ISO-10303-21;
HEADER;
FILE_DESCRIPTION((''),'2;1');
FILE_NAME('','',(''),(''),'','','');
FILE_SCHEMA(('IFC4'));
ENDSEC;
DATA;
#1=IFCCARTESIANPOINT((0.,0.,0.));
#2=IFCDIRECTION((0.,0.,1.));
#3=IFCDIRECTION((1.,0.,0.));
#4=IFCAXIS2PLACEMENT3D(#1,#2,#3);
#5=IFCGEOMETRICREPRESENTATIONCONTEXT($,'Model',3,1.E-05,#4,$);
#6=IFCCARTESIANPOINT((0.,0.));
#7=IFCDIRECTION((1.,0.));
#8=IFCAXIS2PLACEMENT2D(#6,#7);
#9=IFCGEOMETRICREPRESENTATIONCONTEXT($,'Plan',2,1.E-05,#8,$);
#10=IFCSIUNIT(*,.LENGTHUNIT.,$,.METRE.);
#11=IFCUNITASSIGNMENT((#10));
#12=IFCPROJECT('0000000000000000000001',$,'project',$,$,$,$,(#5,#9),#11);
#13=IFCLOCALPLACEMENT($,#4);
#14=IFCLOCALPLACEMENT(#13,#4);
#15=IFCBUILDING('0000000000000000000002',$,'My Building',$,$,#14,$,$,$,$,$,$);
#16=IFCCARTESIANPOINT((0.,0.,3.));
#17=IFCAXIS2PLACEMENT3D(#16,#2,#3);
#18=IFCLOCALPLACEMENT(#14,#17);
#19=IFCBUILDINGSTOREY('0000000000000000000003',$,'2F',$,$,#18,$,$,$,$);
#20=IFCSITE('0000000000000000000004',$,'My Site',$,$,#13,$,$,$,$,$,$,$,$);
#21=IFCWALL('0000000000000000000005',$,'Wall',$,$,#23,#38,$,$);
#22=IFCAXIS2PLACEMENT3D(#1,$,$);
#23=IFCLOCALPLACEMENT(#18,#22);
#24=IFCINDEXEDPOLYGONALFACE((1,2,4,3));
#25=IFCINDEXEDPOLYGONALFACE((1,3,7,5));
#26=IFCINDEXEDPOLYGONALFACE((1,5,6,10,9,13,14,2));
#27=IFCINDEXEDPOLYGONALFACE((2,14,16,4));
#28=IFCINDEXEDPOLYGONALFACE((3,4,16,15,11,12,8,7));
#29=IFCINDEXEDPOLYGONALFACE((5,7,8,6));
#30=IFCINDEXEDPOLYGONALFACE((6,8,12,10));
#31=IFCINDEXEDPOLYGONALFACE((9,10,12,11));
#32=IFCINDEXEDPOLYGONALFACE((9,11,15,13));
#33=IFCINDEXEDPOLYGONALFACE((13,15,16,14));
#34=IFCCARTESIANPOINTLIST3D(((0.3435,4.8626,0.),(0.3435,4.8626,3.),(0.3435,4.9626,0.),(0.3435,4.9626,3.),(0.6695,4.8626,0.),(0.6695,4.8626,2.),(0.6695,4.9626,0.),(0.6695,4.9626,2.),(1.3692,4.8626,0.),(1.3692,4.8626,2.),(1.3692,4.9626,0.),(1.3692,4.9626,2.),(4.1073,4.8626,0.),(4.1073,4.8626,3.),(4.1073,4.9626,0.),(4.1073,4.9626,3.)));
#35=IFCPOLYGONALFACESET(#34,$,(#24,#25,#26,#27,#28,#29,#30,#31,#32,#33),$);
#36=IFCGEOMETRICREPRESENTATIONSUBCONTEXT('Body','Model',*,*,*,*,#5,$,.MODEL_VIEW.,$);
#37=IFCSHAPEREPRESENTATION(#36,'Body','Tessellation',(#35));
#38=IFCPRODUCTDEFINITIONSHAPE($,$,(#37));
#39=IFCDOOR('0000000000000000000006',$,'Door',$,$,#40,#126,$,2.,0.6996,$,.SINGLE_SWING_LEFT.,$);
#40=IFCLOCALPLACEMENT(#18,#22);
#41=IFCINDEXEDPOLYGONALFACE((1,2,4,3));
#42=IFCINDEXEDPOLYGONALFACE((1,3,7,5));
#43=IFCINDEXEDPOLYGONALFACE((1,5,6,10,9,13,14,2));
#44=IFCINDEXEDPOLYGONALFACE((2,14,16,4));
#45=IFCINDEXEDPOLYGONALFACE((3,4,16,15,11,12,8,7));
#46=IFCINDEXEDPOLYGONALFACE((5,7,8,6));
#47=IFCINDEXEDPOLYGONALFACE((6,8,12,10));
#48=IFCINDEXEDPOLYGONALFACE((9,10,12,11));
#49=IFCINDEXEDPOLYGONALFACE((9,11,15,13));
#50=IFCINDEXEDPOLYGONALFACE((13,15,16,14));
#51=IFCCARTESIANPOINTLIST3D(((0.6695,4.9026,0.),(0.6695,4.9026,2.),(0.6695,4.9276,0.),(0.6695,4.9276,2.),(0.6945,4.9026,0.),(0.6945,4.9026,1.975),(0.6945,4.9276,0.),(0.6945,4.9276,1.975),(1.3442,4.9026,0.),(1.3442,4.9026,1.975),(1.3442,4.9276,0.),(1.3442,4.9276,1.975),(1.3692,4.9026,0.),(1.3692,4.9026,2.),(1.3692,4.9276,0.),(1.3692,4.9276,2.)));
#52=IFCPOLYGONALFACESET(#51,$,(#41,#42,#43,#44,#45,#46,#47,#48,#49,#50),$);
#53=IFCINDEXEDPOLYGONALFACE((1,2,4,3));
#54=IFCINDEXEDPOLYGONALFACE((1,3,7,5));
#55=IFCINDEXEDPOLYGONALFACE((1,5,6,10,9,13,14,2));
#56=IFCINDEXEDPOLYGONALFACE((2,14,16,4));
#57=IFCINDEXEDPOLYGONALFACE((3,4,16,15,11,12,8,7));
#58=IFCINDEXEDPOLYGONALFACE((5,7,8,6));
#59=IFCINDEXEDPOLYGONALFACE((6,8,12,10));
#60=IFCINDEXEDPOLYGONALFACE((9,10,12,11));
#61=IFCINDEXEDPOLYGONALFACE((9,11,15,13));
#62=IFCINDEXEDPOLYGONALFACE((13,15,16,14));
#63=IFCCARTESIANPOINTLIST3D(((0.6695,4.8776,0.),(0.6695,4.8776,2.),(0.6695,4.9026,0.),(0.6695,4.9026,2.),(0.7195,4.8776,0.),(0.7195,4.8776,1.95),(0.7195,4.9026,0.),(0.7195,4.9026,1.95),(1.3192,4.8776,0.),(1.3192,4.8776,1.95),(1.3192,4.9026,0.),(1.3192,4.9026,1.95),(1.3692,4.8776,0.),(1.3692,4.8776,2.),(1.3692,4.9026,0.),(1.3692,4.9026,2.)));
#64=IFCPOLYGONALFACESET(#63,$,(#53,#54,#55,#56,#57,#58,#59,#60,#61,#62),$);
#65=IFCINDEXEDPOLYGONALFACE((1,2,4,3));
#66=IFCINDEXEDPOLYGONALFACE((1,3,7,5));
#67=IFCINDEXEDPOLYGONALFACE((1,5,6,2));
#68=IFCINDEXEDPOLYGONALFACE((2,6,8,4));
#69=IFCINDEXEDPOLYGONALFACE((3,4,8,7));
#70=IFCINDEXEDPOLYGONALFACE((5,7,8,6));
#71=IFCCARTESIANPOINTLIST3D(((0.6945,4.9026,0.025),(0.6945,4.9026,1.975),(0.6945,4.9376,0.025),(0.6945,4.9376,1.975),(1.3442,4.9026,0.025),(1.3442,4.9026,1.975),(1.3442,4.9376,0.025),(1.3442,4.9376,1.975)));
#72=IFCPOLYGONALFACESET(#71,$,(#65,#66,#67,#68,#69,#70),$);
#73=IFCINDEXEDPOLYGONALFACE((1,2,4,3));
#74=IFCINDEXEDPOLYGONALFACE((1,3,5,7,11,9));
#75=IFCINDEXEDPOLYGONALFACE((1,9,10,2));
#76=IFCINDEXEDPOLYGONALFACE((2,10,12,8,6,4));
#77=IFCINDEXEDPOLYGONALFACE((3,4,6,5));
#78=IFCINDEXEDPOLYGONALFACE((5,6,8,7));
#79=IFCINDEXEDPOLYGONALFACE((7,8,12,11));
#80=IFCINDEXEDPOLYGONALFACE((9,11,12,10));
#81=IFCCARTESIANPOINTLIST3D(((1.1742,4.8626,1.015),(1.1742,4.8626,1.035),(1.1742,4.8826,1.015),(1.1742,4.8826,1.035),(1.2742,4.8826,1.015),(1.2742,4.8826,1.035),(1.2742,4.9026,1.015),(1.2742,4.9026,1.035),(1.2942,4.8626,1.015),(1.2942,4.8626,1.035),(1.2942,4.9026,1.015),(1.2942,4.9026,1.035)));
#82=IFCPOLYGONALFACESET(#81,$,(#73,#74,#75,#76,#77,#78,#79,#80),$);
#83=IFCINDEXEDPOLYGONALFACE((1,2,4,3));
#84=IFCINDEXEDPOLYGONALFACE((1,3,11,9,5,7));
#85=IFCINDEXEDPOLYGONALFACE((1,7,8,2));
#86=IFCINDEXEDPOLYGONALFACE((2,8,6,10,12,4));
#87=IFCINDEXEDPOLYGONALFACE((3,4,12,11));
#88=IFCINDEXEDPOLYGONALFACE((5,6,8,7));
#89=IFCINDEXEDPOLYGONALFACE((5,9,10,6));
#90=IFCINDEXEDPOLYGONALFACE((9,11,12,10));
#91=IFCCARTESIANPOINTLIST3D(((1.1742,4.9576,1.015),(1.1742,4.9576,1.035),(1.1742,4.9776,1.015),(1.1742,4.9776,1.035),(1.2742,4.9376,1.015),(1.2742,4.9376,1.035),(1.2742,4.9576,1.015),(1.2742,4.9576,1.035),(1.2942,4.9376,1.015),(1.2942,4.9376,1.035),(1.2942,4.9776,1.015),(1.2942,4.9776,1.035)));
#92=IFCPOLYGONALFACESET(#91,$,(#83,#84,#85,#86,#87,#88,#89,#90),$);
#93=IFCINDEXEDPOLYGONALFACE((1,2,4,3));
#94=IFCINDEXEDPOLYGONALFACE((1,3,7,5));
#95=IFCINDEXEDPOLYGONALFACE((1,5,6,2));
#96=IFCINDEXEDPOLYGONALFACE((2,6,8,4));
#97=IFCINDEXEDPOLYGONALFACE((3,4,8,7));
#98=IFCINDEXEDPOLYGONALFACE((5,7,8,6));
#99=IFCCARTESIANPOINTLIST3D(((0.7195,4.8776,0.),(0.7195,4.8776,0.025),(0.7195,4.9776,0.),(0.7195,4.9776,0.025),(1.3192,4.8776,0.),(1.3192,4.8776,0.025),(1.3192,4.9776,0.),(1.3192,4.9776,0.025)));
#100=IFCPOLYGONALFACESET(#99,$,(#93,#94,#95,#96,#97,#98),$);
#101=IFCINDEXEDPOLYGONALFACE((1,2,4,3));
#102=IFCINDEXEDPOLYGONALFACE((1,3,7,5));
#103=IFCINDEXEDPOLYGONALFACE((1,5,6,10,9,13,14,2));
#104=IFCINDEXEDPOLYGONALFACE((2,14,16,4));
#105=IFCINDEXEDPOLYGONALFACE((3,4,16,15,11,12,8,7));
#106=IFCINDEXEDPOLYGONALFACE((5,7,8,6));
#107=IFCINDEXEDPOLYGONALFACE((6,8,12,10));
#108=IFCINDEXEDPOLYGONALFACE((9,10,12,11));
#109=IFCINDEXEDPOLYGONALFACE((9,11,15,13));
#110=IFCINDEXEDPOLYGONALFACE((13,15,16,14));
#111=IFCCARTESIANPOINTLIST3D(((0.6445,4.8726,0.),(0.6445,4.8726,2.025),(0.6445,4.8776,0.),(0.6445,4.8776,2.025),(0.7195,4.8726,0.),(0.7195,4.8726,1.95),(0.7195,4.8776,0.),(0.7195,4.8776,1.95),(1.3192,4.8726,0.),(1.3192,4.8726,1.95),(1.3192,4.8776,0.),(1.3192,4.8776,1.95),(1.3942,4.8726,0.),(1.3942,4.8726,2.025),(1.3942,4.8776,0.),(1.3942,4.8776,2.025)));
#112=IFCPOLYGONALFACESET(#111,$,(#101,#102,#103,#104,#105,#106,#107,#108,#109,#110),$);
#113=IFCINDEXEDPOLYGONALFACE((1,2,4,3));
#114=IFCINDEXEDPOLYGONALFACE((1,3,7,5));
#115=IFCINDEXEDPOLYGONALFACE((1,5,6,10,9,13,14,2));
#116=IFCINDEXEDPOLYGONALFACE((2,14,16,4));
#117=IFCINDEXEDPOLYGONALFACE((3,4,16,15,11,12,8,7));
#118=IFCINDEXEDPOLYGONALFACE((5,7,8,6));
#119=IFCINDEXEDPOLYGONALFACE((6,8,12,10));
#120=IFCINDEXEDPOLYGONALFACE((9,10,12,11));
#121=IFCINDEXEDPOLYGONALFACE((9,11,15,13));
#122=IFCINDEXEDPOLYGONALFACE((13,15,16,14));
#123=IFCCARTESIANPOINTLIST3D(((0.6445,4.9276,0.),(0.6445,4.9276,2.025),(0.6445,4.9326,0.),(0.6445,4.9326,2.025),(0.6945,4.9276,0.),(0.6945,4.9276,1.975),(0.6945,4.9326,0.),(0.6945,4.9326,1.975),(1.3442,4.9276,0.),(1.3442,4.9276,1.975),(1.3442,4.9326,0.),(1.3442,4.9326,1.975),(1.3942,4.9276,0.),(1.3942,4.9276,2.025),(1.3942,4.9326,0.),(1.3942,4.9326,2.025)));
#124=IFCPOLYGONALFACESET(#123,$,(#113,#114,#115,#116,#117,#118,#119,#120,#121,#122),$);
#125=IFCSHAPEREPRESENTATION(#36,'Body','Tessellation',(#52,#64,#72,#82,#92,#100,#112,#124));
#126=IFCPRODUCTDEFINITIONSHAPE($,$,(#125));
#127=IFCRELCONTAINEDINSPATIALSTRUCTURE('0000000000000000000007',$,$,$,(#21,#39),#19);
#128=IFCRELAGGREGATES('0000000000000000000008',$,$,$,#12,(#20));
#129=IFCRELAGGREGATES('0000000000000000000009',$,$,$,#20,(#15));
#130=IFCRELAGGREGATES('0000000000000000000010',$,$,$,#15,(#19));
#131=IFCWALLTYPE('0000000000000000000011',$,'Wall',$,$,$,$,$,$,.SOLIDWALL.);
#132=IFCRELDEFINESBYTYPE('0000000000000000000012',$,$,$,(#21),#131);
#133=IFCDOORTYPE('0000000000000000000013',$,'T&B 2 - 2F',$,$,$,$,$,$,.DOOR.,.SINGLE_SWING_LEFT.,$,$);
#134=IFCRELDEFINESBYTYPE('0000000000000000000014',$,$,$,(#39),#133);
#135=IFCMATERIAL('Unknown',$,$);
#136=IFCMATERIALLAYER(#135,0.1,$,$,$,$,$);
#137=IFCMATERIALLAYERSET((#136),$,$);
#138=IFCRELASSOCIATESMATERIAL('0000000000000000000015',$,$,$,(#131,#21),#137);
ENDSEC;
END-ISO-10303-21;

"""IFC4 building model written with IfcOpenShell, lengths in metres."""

from ifc_helpers import new_model, entity, si_unit, frame, origin_with_axes, origin_2d_with_axis, place, context, subcontext, project, spatial, line, indexed_curve, outline, extrude, shape, source, transform, mapped, material, layer, layer_set, layer_usage, type_object, type_shapes, element, fill, save


model = new_model("IFC4")

# Units and contexts
model_context = context("Model", 3, precision=1e-05, world=origin_with_axes())
plan_context = context("Plan", 2, precision=1e-05, world=origin_2d_with_axis())
body_context_1 = subcontext(model_context, "Body", "Model", "MODEL_VIEW")
body_context_2 = subcontext(plan_context, "Body", "Plan", "PLAN_VIEW")
ifc_project = project(units=[si_unit("LENGTHUNIT", "METRE")], contexts=[model_context, plan_context])

# Site, building, storey
site_placement = place(None, origin_with_axes())
site = spatial("IfcSite", under=ifc_project, at=site_placement, Name="My Site")
building_placement = place(site_placement, origin_with_axes())
building = spatial("IfcBuilding", under=site, at=building_placement, Name="My Building")
storey_placement = place(building_placement, frame((0.0, 0.0, 3.0), z_axis=(0.0, 0.0, 1.0), x_axis=(1.0, 0.0, 0.0)))
storey = spatial("IfcBuildingStorey", under=building, at=storey_placement, Name="2F")

# Shared definitions
ifc_material_1 = material(Name="Unknown")
ifc_layer_1 = layer(ifc_material_1, 0.1)
ifc_layer_set_1 = layer_set([ifc_layer_1])
wall_type_1 = type_object("IfcWallType", Name="Wall", PredefinedType="SOLIDWALL", material=ifc_layer_set_1)

# Wall, opening, door
ifc_layer_usage_1 = layer_usage(ifc_layer_set_1, "AXIS2", "POSITIVE", 0.0)
wall_1_placement = place(storey_placement, frame((4.2073, 4.9626, 0.0), z_axis=(0.0, 0.0, 1.0), x_axis=(-1.0, 0.0, 0.0)))
wall_1 = element("IfcWall", 1, at=wall_1_placement, inside=storey, type_object=wall_type_1, material=ifc_layer_usage_1, Name="Wall", context=body_context_1, shape_type="SweptSolid", body=[
    extrude(outline(indexed_curve([(0.1, 0.0), (0.1, 0.1), (3.8638, 0.1), (3.8638, 0.0)], segments=[line(1, 2, 3, 4, 1)])), origin_with_axes(), (0.0, 0.0, 1.0), 3.0),
])
shared_shape_1 = source(origin_with_axes(), body_context_1, "Body", "SweptSolid", [
    extrude(outline(indexed_curve([(0.0, 0.0), (0.6996, 0.0), (0.6996, 2.0), (0.0, 2.0)], segments=[line(1, 2, 3, 4, 1)])), frame((0.0, -0.6, 0.0), z_axis=(0.0, -1.0, 0.0), x_axis=(1.0, 0.0, 0.0)), (0.0, 0.0, -1.0), 1.2),
])
opening_1_placement = place(wall_1_placement, frame((3.5378, 0.085, 0.0), z_axis=(0.0, 0.0, 1.0), x_axis=(-1.0, 0.0, 0.0)))
opening_1 = element("IfcOpeningElement", 2, at=opening_1_placement, cuts=wall_1, PredefinedType="OPENING", context=body_context_1, shape_type="MappedRepresentation", body=[
    mapped(shared_shape_1, transform((0.0, 0.0, 0.0), x_axis=(1.0, 0.0, 0.0), y_axis=(0.0, 1.0, 0.0), z_axis=(0.0, 0.0, 1.0), scale=1.0)),
])
door_type_1 = type_object("IfcDoorType", Name="T&B 2 - 2F", OperationType="SINGLE_SWING_LEFT", PredefinedType="DOOR")
shared_shape_2 = source(origin_with_axes(), body_context_1, "Body", "SweptSolid", [
    extrude(outline(indexed_curve([(0.0, 0.0), (0.0, 2.0), (0.6996, 2.0), (0.6996, 0.0), (0.6746, 0.0), (0.6746, 1.975), (0.025, 1.975), (0.025, 0.0)], segments=[line(1, 2, 3, 4, 5, 6, 7, 8, 1)])), frame((0.0, 0.025, 0.0), z_axis=(0.0, -1.0, 0.0), x_axis=(1.0, 0.0, 0.0)), (0.0, 0.0, -1.0), 0.025),
    extrude(outline(indexed_curve([(0.0, 0.0), (0.0, 2.0), (0.6996, 2.0), (0.6996, 0.0), (0.6496, 0.0), (0.6496, 1.95), (0.05, 1.95), (0.05, 0.0)], segments=[line(1, 2, 3, 4, 5, 6, 7, 8, 1)])), frame((0.0, 0.0, 0.0), z_axis=(0.0, -1.0, 0.0), x_axis=(1.0, 0.0, 0.0)), (0.0, 0.0, -1.0), 0.025),
    extrude(outline(indexed_curve([(0.0, 0.0), (0.6496, 0.0), (0.6496, 0.035), (0.0, 0.035)], segments=[line(1, 2, 3, 4, 1)])), frame((0.025, 0.025, 0.025), z_axis=(0.0, 0.0, 1.0), x_axis=(1.0, 0.0, 0.0)), (0.0, 0.0, 1.0), 1.95),
    extrude(outline(indexed_curve([(0.0, 0.0), (0.0, -0.04), (-0.12, -0.04), (-0.12, -0.02), (-0.02, -0.02), (-0.02, 0.0)], segments=[line(1, 2, 3, 4, 5, 6, 1)])), frame((0.6246, 0.025, 1.015), z_axis=(0.0, 0.0, 1.0), x_axis=(1.0, 0.0, 0.0)), (0.0, 0.0, 1.0), 0.02),
    extrude(outline(indexed_curve([(0.0, 0.0), (0.0, 0.04), (-0.12, 0.04), (-0.12, 0.02), (-0.02, 0.02), (-0.02, 0.0)], segments=[line(1, 2, 3, 4, 5, 6, 1)])), frame((0.6246, 0.06, 1.015), z_axis=(0.0, 0.0, 1.0), x_axis=(1.0, 0.0, 0.0)), (0.0, 0.0, 1.0), 0.02),
    extrude(outline(indexed_curve([(0.0, 0.0), (0.5996, 0.0), (0.5996, 0.1), (0.0, 0.1)], segments=[line(1, 2, 3, 4, 1)])), frame((0.05, 0.0, 0.0), z_axis=(0.0, 0.0, 1.0), x_axis=(1.0, 0.0, 0.0)), (0.0, 0.0, 1.0), 0.025),
    extrude(outline(indexed_curve([(0.0, 0.0), (0.0, 2.025), (0.7496, 2.025), (0.7496, 0.0), (0.6746, 0.0), (0.6746, 1.95), (0.075, 1.95), (0.075, 0.0)], segments=[line(1, 2, 3, 4, 5, 6, 7, 8, 1)])), frame((-0.025, -0.005, 0.0), z_axis=(0.0, -1.0, 0.0), x_axis=(1.0, 0.0, 0.0)), (0.0, 0.0, -1.0), 0.005),
    extrude(outline(indexed_curve([(0.0, 0.0), (0.0, 2.025), (0.7496, 2.025), (0.7496, 0.0), (0.6996, 0.0), (0.6996, 1.975), (0.05, 1.975), (0.05, 0.0)], segments=[line(1, 2, 3, 4, 5, 6, 7, 8, 1)])), frame((-0.025, 0.05, 0.0), z_axis=(0.0, -1.0, 0.0), x_axis=(1.0, 0.0, 0.0)), (0.0, 0.0, -1.0), 0.005),
])
shared_shape_3 = source(origin_with_axes(), body_context_2, "Body", "Curve2D", [
    entity("IfcIndexedPolyCurve", entity("IfcCartesianPointList2D", [[0.0, 0.0], [0.0, 0.05], [0.025, 0.05], [0.025, 0.025], [0.05, 0.025], [0.05, 0.0]]), [entity("IfcLineIndex", [1, 2, 3, 4, 5, 6, 1])]),
    entity("IfcIndexedPolyCurve", entity("IfcCartesianPointList2D", [[0.6996, 0.0], [0.6996, 0.05], [0.6746, 0.05], [0.6746, 0.025], [0.6496, 0.025], [0.6496, 0.0]]), [entity("IfcLineIndex", [1, 2, 3, 4, 5, 6, 1])]),
    entity("IfcTrimmedCurve", entity("IfcEllipse", entity("IfcAxis2Placement2D", entity("IfcCartesianPoint", [0.06, 0.05]), entity("IfcDirection", [1.0, 0.0])), 0.6146, 0.6496), [entity("IfcCartesianPoint", [0.6746, 0.05])], [entity("IfcCartesianPoint", [0.06, 0.6996])], True, "CARTESIAN"),
    entity("IfcIndexedPolyCurve", entity("IfcCartesianPointList2D", [[0.025, 0.05], [0.06, 0.05], [0.06, 0.6996], [0.025, 0.6996]]), [entity("IfcLineIndex", [1, 2, 3, 4, 1])]),
])
type_shapes(door_type_1, [shared_shape_2, shared_shape_3])
door_1_placement = place(opening_1_placement, frame((0.0, 0.0, 0.0), z_axis=(0.0, 0.0, 1.0), x_axis=(1.0, 0.0, 0.0)))
door_1 = element("IfcDoor", 3, at=door_1_placement, inside=storey, type_object=door_type_1, Name="Door", OperationType="SINGLE_SWING_LEFT", OverallHeight=2.0, OverallWidth=0.6996, shapes=[
    shape(body_context_1, "Body", "MappedRepresentation", [mapped(shared_shape_2, transform((0.0, 0.0, 0.0), x_axis=(1.0, 0.0, 0.0), y_axis=(0.0, 1.0, 0.0), z_axis=(0.0, 0.0, 1.0), scale=1.0))]),
    shape(body_context_2, "Body", "MappedRepresentation", [mapped(shared_shape_3, transform((0.0, 0.0, 0.0), x_axis=(1.0, 0.0, 0.0), y_axis=(0.0, 1.0, 0.0), z_axis=(0.0, 0.0, 1.0), scale=1.0))]),
])
fill(opening_1, door_1)

save(model, "model.ifc")
